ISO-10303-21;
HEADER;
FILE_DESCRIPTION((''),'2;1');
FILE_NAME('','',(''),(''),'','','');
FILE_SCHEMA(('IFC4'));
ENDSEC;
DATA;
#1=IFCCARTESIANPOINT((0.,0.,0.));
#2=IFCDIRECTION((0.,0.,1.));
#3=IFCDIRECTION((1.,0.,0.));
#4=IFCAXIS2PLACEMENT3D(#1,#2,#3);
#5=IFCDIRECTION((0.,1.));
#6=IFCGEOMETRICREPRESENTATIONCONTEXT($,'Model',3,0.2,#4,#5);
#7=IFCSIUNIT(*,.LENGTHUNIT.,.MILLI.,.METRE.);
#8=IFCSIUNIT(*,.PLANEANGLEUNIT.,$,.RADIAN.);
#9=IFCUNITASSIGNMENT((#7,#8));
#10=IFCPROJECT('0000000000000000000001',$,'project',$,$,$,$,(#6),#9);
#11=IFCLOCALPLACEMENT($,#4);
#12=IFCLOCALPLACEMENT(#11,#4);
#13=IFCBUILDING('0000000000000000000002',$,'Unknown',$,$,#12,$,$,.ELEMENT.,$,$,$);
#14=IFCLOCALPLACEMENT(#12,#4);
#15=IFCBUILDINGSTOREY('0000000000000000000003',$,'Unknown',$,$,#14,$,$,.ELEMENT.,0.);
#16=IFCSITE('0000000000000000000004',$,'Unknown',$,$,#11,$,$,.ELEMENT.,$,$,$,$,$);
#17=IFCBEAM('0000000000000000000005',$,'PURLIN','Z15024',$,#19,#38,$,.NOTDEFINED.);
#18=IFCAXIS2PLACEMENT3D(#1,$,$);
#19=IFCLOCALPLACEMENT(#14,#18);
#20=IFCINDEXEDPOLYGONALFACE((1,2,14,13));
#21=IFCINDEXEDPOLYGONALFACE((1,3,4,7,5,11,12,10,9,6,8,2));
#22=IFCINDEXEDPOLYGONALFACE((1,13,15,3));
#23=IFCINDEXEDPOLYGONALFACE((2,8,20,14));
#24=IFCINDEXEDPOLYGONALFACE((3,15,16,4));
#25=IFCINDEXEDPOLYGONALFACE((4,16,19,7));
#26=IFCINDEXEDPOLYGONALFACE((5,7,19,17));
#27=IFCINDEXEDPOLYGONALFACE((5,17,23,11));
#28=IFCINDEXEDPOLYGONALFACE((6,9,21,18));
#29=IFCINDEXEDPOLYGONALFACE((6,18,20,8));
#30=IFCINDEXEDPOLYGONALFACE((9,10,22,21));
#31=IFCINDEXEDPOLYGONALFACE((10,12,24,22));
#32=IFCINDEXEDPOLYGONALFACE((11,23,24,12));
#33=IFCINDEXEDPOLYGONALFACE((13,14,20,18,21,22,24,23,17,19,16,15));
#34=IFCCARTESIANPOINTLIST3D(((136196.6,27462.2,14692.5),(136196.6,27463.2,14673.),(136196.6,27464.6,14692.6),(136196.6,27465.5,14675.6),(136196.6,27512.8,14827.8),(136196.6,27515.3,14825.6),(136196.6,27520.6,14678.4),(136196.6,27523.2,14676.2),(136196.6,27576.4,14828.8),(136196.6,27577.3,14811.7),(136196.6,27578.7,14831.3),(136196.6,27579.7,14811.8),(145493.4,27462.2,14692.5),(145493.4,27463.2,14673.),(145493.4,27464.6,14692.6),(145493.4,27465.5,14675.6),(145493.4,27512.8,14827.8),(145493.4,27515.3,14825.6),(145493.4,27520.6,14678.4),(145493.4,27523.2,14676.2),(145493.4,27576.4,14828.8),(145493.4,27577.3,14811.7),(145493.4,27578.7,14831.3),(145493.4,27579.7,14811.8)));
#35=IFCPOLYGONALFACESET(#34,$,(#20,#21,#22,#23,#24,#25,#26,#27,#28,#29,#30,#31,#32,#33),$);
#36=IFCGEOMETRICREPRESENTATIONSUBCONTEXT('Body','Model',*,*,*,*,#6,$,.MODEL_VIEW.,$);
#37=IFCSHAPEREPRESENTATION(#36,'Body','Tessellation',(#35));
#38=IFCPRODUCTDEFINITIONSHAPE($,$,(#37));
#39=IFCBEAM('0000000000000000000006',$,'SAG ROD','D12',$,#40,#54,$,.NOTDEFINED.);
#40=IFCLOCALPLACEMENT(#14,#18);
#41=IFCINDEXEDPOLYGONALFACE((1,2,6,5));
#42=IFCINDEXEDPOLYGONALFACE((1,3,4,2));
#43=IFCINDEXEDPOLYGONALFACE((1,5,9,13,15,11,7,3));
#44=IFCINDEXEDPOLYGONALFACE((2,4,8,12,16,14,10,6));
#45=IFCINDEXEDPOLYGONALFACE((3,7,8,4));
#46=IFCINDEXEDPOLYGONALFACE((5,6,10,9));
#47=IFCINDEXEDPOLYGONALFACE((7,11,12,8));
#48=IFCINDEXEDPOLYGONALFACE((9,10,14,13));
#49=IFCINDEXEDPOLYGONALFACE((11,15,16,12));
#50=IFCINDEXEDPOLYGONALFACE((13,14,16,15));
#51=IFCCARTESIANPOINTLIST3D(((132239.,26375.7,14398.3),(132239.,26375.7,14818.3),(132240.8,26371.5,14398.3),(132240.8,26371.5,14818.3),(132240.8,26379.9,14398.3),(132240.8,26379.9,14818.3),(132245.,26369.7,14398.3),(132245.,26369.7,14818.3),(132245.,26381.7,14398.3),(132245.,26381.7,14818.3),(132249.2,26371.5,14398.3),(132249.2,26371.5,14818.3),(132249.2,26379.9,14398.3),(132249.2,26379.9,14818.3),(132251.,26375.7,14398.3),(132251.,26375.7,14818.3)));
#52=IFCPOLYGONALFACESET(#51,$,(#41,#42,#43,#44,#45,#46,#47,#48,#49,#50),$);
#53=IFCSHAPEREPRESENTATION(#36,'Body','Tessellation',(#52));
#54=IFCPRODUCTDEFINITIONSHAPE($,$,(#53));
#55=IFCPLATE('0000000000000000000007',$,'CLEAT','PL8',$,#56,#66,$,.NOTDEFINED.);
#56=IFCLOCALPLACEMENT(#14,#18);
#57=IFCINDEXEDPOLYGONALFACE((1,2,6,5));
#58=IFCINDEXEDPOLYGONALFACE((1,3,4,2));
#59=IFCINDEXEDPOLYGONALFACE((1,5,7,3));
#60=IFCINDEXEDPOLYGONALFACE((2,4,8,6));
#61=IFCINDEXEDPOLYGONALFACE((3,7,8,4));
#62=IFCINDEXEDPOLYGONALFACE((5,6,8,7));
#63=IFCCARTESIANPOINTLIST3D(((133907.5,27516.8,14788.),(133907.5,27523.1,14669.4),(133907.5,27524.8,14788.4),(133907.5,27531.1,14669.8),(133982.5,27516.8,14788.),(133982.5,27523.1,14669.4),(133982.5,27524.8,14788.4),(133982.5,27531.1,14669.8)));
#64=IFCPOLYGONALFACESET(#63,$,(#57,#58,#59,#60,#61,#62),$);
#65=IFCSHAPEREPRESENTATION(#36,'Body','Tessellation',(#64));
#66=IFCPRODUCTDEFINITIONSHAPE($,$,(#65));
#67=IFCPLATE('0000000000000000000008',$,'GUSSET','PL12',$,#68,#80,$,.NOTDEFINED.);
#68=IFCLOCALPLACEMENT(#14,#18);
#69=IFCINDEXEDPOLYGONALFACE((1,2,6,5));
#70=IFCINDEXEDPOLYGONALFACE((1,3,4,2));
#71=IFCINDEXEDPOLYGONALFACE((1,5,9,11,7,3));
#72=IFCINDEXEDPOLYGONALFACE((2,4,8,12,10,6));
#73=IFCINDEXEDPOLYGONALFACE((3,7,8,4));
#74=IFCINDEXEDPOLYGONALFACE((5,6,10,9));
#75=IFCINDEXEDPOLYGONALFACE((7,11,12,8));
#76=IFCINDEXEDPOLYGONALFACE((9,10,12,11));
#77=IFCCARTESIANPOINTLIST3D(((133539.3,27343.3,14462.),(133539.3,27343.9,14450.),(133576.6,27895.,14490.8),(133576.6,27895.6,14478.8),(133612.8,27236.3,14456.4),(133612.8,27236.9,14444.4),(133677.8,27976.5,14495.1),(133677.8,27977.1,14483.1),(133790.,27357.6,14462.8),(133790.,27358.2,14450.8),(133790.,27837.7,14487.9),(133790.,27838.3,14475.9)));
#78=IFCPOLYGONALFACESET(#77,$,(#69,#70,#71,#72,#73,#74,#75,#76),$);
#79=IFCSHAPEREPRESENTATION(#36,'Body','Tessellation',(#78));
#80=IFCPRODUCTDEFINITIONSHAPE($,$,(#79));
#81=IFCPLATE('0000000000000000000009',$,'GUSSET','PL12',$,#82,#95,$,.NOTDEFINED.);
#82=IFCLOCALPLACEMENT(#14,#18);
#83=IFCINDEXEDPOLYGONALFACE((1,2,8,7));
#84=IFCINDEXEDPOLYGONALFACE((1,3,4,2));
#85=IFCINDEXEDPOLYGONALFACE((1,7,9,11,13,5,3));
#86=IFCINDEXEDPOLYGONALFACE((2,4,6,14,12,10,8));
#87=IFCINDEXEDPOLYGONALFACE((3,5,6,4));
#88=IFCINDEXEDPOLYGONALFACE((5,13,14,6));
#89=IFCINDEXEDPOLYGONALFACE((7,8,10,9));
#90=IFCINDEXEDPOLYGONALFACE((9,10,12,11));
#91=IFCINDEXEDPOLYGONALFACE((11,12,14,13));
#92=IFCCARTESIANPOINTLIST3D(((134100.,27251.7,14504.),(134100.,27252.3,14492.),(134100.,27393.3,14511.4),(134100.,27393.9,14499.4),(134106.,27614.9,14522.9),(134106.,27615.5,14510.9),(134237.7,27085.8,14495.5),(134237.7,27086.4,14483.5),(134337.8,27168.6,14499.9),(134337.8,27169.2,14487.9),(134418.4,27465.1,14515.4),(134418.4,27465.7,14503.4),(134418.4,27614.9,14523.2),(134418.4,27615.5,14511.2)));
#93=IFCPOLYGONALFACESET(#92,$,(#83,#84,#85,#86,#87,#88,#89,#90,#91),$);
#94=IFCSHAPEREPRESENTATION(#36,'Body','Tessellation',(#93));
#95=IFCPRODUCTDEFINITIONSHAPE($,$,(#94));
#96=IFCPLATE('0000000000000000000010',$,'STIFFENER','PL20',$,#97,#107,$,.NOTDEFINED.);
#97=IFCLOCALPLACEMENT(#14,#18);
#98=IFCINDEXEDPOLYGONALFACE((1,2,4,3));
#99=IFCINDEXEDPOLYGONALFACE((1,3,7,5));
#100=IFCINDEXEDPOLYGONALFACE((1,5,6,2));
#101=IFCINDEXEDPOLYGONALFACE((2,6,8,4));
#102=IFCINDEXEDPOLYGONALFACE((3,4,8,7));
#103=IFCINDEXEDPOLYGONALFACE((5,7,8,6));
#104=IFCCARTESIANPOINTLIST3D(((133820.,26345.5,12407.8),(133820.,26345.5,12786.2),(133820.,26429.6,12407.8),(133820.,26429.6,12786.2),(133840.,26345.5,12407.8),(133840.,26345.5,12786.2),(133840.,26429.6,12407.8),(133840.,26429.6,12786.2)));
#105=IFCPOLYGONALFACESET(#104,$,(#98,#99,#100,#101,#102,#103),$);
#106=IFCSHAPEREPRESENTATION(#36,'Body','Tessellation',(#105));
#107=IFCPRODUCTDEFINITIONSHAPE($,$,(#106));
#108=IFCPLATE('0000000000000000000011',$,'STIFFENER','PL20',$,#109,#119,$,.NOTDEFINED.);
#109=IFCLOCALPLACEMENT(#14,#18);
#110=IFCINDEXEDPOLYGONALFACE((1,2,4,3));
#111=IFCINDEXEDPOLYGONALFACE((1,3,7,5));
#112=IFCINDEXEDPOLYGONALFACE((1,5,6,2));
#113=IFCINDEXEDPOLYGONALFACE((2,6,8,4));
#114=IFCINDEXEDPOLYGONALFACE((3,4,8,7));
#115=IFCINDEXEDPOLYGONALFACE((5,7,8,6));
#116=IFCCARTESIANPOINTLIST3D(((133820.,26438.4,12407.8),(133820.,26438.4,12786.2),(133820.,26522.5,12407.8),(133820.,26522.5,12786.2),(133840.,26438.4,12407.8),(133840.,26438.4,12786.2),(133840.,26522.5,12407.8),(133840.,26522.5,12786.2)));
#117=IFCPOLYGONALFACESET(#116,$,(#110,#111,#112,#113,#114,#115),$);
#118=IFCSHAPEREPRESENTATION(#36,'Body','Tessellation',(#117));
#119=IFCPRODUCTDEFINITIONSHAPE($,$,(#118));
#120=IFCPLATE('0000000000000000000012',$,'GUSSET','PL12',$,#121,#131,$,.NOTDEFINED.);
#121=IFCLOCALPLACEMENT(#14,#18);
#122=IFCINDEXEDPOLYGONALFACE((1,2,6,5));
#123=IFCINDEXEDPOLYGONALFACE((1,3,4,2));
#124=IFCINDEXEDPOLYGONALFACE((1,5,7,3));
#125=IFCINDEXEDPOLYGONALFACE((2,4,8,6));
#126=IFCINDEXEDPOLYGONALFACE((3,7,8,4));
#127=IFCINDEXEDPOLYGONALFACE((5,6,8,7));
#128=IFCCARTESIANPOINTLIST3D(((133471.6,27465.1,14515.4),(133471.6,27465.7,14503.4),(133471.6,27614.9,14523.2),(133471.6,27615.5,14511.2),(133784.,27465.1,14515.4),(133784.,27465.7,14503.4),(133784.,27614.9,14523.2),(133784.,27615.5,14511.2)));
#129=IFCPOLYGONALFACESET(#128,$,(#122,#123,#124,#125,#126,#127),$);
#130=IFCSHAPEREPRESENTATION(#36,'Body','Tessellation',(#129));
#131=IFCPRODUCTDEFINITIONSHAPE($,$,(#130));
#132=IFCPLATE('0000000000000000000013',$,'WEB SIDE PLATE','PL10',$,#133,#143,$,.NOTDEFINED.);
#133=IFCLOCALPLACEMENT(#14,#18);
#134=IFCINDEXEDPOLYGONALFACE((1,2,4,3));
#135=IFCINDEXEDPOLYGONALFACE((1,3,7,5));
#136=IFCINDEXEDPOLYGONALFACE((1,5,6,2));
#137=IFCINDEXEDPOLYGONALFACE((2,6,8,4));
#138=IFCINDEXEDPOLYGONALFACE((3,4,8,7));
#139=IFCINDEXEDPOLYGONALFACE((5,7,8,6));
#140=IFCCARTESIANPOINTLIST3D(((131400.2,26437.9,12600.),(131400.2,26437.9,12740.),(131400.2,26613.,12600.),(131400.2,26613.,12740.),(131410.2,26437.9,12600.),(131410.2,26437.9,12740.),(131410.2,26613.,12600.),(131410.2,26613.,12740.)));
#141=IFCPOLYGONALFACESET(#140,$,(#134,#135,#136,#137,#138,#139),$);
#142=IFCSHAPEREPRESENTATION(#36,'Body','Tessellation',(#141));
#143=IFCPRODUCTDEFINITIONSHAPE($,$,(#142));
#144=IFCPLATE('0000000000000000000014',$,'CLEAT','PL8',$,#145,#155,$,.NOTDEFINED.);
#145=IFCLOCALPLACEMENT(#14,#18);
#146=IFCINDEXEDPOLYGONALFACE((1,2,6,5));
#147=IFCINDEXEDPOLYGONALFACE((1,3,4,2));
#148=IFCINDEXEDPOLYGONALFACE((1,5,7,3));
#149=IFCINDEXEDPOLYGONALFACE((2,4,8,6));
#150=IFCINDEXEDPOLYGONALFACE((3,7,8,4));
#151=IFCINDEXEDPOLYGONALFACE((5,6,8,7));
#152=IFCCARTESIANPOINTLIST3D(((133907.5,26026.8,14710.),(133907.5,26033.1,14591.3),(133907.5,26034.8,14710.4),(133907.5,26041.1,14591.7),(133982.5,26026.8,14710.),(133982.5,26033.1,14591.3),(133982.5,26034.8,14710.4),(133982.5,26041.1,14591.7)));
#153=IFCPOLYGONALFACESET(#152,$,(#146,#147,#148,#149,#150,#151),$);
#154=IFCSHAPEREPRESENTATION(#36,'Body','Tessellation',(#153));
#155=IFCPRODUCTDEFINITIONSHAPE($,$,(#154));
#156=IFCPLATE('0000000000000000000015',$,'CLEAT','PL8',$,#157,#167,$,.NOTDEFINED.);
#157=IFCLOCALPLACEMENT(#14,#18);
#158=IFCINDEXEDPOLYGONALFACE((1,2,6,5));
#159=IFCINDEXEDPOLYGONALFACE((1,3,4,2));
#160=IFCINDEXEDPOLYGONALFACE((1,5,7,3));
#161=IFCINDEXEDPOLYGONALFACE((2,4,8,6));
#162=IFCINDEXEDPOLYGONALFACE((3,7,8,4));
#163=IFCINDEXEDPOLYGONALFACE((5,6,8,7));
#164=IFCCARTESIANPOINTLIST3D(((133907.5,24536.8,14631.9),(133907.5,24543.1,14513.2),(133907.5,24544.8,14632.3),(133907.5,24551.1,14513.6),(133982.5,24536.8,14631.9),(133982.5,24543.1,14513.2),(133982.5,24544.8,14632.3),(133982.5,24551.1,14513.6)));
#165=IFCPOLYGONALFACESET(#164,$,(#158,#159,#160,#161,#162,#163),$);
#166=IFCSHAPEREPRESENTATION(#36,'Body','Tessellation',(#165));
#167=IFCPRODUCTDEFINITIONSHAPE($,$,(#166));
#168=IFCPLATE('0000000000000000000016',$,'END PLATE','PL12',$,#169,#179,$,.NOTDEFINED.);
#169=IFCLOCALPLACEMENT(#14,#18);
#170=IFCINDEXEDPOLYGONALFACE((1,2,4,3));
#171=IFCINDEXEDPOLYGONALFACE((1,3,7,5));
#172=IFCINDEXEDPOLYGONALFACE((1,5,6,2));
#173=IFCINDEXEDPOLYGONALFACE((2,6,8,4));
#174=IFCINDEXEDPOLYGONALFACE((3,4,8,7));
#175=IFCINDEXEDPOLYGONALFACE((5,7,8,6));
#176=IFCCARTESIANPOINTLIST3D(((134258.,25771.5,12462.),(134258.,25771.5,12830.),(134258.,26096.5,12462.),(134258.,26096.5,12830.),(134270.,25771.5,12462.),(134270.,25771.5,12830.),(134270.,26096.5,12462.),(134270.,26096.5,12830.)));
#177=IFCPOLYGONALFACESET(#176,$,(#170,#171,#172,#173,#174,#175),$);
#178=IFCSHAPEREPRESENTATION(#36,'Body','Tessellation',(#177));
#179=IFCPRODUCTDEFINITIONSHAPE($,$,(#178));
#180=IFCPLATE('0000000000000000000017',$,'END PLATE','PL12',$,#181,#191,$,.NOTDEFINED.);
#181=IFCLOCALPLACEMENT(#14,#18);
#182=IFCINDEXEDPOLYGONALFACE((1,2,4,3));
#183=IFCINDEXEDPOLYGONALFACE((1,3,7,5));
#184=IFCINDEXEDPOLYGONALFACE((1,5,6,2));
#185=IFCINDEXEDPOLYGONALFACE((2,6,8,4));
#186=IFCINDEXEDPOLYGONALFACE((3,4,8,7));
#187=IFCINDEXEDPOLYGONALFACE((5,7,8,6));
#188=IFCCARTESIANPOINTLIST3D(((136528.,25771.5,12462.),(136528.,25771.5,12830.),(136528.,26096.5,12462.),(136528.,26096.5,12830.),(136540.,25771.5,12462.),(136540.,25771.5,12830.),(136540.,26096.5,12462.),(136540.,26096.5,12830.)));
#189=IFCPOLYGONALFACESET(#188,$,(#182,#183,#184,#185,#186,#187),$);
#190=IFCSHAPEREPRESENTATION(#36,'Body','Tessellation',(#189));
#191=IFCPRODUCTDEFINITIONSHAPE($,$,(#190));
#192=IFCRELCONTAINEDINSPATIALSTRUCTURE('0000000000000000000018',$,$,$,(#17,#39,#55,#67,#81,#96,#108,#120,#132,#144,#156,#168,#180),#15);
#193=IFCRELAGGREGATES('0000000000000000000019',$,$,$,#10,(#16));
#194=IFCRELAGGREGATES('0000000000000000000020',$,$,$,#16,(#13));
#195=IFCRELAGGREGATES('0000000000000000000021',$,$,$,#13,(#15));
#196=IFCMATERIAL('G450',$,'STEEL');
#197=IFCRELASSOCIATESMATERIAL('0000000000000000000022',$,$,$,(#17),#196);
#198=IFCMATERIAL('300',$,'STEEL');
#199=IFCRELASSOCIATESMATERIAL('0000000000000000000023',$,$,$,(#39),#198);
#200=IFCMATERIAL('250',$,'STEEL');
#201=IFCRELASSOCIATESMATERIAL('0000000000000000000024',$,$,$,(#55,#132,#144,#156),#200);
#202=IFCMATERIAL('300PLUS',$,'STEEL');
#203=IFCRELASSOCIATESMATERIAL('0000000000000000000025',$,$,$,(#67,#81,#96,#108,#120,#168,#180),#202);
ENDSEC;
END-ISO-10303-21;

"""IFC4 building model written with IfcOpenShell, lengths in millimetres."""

from ifc_helpers import new_model, si_unit, direction, frame, origin_with_axes, place, context, subcontext, project, spatial, line, indexed_curve, outline, extrude, material, element, save


model = new_model("IFC4")

# Units and contexts
model_context = context("Model", 3, precision=0.2, world=origin_with_axes(), true_north=direction((0.0, 1.0)))
body_context = subcontext(model_context, "Body", "Model", "MODEL_VIEW")
ifc_project = project(units=[si_unit("LENGTHUNIT", "METRE", prefix="MILLI"), si_unit("PLANEANGLEUNIT", "RADIAN")], contexts=[model_context])

# Site, building, storey
site_placement = place(None, origin_with_axes())
site = spatial("IfcSite", under=ifc_project, at=site_placement, Name="Unknown", CompositionType="ELEMENT")
building_placement = place(site_placement, origin_with_axes())
building = spatial("IfcBuilding", under=site, at=building_placement, Name="Unknown", CompositionType="ELEMENT")
storey_placement = place(building_placement, origin_with_axes())
storey = spatial("IfcBuildingStorey", under=building, at=storey_placement, Name="Unknown", CompositionType="ELEMENT", Elevation=0.0)

# Beams
ifc_material_1 = material(Name="300PLUS", Category="STEEL")
ifc_material_2 = material(Name="G450", Category="STEEL")
for number, where, z_axis, x_axis, name in (
    (1, (136196.6, 27518.0, 14752.0), (0.0, -0.99863, -0.052336), (1.0, 0.0, 0.0), "PURLIN"),
):
    element("IfcBeam", number, at=place(storey_placement, frame(where, z_axis=z_axis, x_axis=x_axis)), inside=storey, material=ifc_material_2, Name=name, Description="Z15024", PredefinedType="NOTDEFINED", context=body_context, shape_type="SolidModel", body=[
        extrude(outline(indexed_curve([(58.8, -76.0), (58.8, -56.5), (56.4, -56.5), (56.4, -73.6), (1.2, -73.6), (1.2, 76.0), (-64.8, 76.0), (-64.8, 56.5), (-62.4, 56.5), (-62.4, 73.6), (-1.2, 73.6), (-1.2, -76.0)], segments=[line(1, 2, 3, 4, 5, 6, 7, 8, 9, 10, 11, 12, 1)])), frame((0.0, 0.0, 0.0), z_axis=(-1.0, 0.0, 0.0), x_axis=(0.0, 0.0, 1.0)), (0.0, 0.0, -1.0), 9296.8),
    ])
ifc_material_3 = material(Name="300", Category="STEEL")
beam_1_placement = place(storey_placement, frame((132245.0, 26375.7, 14818.3), z_axis=(1.0, 0.0, 0.0), x_axis=(0.0, 0.0, -1.0)))
element("IfcBeam", 2, at=beam_1_placement, inside=storey, material=ifc_material_3, Name="SAG ROD", Description="D12", PredefinedType="NOTDEFINED", context=body_context, shape_type="SolidModel", body=[
    extrude(outline(indexed_curve([(6.0, 0.0), (4.2, 4.2), (0.0, 6.0), (-4.2, 4.2), (-6.0, 0.0), (-4.2, -4.2), (0.0, -6.0), (4.2, -4.2)], segments=[line(1, 2, 3, 4, 5, 6, 7, 8, 1)])), frame((0.0, 0.0, 0.0), z_axis=(-1.0, 0.0, 0.0), x_axis=(0.0, 0.0, 1.0)), (0.0, 0.0, -1.0), 420.0),
])

# Plates
ifc_material_4 = material(Name="250", Category="STEEL")
plate_1_placement = place(storey_placement, frame((133907.5, 27520.8, 14788.2), z_axis=(0.0, 0.998592, 0.053045), x_axis=(1.0, 0.0, 0.0)))
element("IfcPlate", 3, at=plate_1_placement, inside=storey, material=ifc_material_4, Name="CLEAT", Description="PL8", PredefinedType="NOTDEFINED", context=body_context, shape_type="SolidModel", body=[
    extrude(outline(indexed_curve([(0.0, 0.0), (75.0, 0.0), (75.0, 118.8), (0.0, 118.8)], segments=[line(1, 2, 3, 4, 1)])), frame((0.0, 0.0, 4.0), z_axis=(0.0, 0.0, 1.0), x_axis=(1.0, 0.0, 0.0)), (0.0, 0.0, -1.0), 8.0),
])
plate_2_placement = place(storey_placement, frame((133790.0, 27357.9, 14456.8), z_axis=(-0.000329, -0.052209, 0.998636), x_axis=(0.0, 0.998636, 0.052209)))
element("IfcPlate", 4, at=plate_2_placement, inside=storey, material=ifc_material_1, Name="GUSSET", Description="PL12", PredefinedType="NOTDEFINED", context=body_context, shape_type="SolidModel", body=[
    extrude(outline(indexed_curve([(0.0, 0.0), (480.8, 0.0), (619.7, 112.2), (538.1, 213.4), (-14.3, 250.7), (-121.5, 177.2)], segments=[line(1, 2, 3, 4, 5, 6, 1)])), frame((0.0, 0.0, 6.0), z_axis=(0.0, 0.0, 1.0), x_axis=(1.0, 0.0, 0.0)), (0.0, 0.0, -1.0), 12.0),
])
plate_3_placement = place(storey_placement, frame((134337.8, 27168.9, 14493.9), z_axis=(-0.00092, -0.051956, 0.998649), x_axis=(0.261986, 0.963756, 0.050382)))
element("IfcPlate", 5, at=plate_3_placement, inside=storey, material=ifc_material_1, Name="GUSSET", Description="PL12", PredefinedType="NOTDEFINED", context=body_context, shape_type="SolidModel", body=[
    extrude(outline(indexed_curve([(0.0, 0.0), (307.7, 0.0), (452.4, 39.3), (370.6, 340.8), (154.8, 288.4), (18.0, 251.3), (-106.2, 74.9)], segments=[line(1, 2, 3, 4, 5, 6, 7, 1)])), frame((0.0, 0.0, 6.0), z_axis=(0.0, 0.0, 1.0), x_axis=(1.0, 0.0, 0.0)), (0.0, 0.0, -1.0), 12.0),
])
for number, where, z_axis, x_axis, name in (
    (6, (133830.0, 26429.6, 12407.8), (1.0, 0.0, 0.0), (0.0, 0.0, 1.0), "STIFFENER"),
    (7, (133830.0, 26522.5, 12407.8), (1.0, 0.0, 0.0), (0.0, 0.0, 1.0), "STIFFENER"),
):
    element("IfcPlate", number, at=place(storey_placement, frame(where, z_axis=z_axis, x_axis=x_axis)), inside=storey, material=ifc_material_1, Name=name, Description="PL20", PredefinedType="NOTDEFINED", context=body_context, shape_type="SolidModel", body=[
        extrude(outline(indexed_curve([(0.0, 0.0), (378.4, 0.0), (378.4, 84.1), (0.0, 84.1)], segments=[line(1, 2, 3, 4, 1)])), frame((0.0, 0.0, 10.0), z_axis=(0.0, 0.0, 1.0), x_axis=(1.0, 0.0, 0.0)), (0.0, 0.0, -1.0), 20.0),
    ])
plate_4_placement = place(storey_placement, frame((133784.0, 27615.2, 14517.2), z_axis=(0.0, -0.051999, 0.998647), x_axis=(-1.0, 0.0, 0.0)))
element("IfcPlate", 8, at=plate_4_placement, inside=storey, material=ifc_material_1, Name="GUSSET", Description="PL12", PredefinedType="NOTDEFINED", context=body_context, shape_type="SolidModel", body=[
    extrude(outline(indexed_curve([(0.0, 0.0), (312.4, 0.0), (312.4, 150.0), (0.0, 150.0)], segments=[line(1, 2, 3, 4, 1)])), frame((0.0, 0.0, 6.0), z_axis=(0.0, 0.0, 1.0), x_axis=(1.0, 0.0, 0.0)), (0.0, 0.0, -1.0), 12.0),
])
plate_5_placement = place(storey_placement, frame((131405.2, 26613.0, 12600.0), z_axis=(1.0, 0.0, 0.0), x_axis=(0.0, 0.0, 1.0)))
element("IfcPlate", 9, at=plate_5_placement, inside=storey, material=ifc_material_4, Name="WEB SIDE PLATE", Description="PL10", PredefinedType="NOTDEFINED", context=body_context, shape_type="SolidModel", body=[
    extrude(outline(indexed_curve([(0.0, 0.0), (140.0, 0.0), (140.0, 175.1), (0.0, 175.1)], segments=[line(1, 2, 3, 4, 1)])), frame((0.0, 0.0, 5.0), z_axis=(0.0, 0.0, 1.0), x_axis=(1.0, 0.0, 0.0)), (0.0, 0.0, -1.0), 10.0),
])
for number, where, z_axis, x_axis, name in (
    (10, (133907.5, 26030.8, 14710.2), (0.0, 0.998594, 0.053), (1.0, 0.0, 0.0), "CLEAT"),
    (11, (133907.5, 24540.8, 14632.1), (0.0, 0.998594, 0.053), (1.0, 0.0, 0.0), "CLEAT"),
):
    element("IfcPlate", number, at=place(storey_placement, frame(where, z_axis=z_axis, x_axis=x_axis)), inside=storey, material=ifc_material_4, Name=name, Description="PL8", PredefinedType="NOTDEFINED", context=body_context, shape_type="SolidModel", body=[
        extrude(outline(indexed_curve([(0.0, 0.0), (75.0, 0.0), (75.0, 118.9), (0.0, 118.9)], segments=[line(1, 2, 3, 4, 1)])), frame((0.0, 0.0, 4.0), z_axis=(0.0, 0.0, 1.0), x_axis=(1.0, 0.0, 0.0)), (0.0, 0.0, -1.0), 8.0),
    ])
for number, where, z_axis, x_axis, name in (
    (12, (134264.0, 26096.5, 12462.0), (-1.0, 0.0, 0.0), (0.0, -1.0, 0.0), "END PLATE"),
    (13, (136534.0, 26096.5, 12462.0), (-1.0, 0.0, 0.0), (0.0, -1.0, 0.0), "END PLATE"),
):
    element("IfcPlate", number, at=place(storey_placement, frame(where, z_axis=z_axis, x_axis=x_axis)), inside=storey, material=ifc_material_1, Name=name, Description="PL12", PredefinedType="NOTDEFINED", context=body_context, shape_type="SolidModel", body=[
        extrude(outline(indexed_curve([(0.0, 0.0), (325.0, 0.0), (325.0, 368.0), (0.0, 368.0)], segments=[line(1, 2, 3, 4, 1)])), frame((0.0, 0.0, 6.0), z_axis=(0.0, 0.0, 1.0), x_axis=(1.0, 0.0, 0.0)), (0.0, 0.0, -1.0), 12.0),
    ])

save(model, "model.ifc")
